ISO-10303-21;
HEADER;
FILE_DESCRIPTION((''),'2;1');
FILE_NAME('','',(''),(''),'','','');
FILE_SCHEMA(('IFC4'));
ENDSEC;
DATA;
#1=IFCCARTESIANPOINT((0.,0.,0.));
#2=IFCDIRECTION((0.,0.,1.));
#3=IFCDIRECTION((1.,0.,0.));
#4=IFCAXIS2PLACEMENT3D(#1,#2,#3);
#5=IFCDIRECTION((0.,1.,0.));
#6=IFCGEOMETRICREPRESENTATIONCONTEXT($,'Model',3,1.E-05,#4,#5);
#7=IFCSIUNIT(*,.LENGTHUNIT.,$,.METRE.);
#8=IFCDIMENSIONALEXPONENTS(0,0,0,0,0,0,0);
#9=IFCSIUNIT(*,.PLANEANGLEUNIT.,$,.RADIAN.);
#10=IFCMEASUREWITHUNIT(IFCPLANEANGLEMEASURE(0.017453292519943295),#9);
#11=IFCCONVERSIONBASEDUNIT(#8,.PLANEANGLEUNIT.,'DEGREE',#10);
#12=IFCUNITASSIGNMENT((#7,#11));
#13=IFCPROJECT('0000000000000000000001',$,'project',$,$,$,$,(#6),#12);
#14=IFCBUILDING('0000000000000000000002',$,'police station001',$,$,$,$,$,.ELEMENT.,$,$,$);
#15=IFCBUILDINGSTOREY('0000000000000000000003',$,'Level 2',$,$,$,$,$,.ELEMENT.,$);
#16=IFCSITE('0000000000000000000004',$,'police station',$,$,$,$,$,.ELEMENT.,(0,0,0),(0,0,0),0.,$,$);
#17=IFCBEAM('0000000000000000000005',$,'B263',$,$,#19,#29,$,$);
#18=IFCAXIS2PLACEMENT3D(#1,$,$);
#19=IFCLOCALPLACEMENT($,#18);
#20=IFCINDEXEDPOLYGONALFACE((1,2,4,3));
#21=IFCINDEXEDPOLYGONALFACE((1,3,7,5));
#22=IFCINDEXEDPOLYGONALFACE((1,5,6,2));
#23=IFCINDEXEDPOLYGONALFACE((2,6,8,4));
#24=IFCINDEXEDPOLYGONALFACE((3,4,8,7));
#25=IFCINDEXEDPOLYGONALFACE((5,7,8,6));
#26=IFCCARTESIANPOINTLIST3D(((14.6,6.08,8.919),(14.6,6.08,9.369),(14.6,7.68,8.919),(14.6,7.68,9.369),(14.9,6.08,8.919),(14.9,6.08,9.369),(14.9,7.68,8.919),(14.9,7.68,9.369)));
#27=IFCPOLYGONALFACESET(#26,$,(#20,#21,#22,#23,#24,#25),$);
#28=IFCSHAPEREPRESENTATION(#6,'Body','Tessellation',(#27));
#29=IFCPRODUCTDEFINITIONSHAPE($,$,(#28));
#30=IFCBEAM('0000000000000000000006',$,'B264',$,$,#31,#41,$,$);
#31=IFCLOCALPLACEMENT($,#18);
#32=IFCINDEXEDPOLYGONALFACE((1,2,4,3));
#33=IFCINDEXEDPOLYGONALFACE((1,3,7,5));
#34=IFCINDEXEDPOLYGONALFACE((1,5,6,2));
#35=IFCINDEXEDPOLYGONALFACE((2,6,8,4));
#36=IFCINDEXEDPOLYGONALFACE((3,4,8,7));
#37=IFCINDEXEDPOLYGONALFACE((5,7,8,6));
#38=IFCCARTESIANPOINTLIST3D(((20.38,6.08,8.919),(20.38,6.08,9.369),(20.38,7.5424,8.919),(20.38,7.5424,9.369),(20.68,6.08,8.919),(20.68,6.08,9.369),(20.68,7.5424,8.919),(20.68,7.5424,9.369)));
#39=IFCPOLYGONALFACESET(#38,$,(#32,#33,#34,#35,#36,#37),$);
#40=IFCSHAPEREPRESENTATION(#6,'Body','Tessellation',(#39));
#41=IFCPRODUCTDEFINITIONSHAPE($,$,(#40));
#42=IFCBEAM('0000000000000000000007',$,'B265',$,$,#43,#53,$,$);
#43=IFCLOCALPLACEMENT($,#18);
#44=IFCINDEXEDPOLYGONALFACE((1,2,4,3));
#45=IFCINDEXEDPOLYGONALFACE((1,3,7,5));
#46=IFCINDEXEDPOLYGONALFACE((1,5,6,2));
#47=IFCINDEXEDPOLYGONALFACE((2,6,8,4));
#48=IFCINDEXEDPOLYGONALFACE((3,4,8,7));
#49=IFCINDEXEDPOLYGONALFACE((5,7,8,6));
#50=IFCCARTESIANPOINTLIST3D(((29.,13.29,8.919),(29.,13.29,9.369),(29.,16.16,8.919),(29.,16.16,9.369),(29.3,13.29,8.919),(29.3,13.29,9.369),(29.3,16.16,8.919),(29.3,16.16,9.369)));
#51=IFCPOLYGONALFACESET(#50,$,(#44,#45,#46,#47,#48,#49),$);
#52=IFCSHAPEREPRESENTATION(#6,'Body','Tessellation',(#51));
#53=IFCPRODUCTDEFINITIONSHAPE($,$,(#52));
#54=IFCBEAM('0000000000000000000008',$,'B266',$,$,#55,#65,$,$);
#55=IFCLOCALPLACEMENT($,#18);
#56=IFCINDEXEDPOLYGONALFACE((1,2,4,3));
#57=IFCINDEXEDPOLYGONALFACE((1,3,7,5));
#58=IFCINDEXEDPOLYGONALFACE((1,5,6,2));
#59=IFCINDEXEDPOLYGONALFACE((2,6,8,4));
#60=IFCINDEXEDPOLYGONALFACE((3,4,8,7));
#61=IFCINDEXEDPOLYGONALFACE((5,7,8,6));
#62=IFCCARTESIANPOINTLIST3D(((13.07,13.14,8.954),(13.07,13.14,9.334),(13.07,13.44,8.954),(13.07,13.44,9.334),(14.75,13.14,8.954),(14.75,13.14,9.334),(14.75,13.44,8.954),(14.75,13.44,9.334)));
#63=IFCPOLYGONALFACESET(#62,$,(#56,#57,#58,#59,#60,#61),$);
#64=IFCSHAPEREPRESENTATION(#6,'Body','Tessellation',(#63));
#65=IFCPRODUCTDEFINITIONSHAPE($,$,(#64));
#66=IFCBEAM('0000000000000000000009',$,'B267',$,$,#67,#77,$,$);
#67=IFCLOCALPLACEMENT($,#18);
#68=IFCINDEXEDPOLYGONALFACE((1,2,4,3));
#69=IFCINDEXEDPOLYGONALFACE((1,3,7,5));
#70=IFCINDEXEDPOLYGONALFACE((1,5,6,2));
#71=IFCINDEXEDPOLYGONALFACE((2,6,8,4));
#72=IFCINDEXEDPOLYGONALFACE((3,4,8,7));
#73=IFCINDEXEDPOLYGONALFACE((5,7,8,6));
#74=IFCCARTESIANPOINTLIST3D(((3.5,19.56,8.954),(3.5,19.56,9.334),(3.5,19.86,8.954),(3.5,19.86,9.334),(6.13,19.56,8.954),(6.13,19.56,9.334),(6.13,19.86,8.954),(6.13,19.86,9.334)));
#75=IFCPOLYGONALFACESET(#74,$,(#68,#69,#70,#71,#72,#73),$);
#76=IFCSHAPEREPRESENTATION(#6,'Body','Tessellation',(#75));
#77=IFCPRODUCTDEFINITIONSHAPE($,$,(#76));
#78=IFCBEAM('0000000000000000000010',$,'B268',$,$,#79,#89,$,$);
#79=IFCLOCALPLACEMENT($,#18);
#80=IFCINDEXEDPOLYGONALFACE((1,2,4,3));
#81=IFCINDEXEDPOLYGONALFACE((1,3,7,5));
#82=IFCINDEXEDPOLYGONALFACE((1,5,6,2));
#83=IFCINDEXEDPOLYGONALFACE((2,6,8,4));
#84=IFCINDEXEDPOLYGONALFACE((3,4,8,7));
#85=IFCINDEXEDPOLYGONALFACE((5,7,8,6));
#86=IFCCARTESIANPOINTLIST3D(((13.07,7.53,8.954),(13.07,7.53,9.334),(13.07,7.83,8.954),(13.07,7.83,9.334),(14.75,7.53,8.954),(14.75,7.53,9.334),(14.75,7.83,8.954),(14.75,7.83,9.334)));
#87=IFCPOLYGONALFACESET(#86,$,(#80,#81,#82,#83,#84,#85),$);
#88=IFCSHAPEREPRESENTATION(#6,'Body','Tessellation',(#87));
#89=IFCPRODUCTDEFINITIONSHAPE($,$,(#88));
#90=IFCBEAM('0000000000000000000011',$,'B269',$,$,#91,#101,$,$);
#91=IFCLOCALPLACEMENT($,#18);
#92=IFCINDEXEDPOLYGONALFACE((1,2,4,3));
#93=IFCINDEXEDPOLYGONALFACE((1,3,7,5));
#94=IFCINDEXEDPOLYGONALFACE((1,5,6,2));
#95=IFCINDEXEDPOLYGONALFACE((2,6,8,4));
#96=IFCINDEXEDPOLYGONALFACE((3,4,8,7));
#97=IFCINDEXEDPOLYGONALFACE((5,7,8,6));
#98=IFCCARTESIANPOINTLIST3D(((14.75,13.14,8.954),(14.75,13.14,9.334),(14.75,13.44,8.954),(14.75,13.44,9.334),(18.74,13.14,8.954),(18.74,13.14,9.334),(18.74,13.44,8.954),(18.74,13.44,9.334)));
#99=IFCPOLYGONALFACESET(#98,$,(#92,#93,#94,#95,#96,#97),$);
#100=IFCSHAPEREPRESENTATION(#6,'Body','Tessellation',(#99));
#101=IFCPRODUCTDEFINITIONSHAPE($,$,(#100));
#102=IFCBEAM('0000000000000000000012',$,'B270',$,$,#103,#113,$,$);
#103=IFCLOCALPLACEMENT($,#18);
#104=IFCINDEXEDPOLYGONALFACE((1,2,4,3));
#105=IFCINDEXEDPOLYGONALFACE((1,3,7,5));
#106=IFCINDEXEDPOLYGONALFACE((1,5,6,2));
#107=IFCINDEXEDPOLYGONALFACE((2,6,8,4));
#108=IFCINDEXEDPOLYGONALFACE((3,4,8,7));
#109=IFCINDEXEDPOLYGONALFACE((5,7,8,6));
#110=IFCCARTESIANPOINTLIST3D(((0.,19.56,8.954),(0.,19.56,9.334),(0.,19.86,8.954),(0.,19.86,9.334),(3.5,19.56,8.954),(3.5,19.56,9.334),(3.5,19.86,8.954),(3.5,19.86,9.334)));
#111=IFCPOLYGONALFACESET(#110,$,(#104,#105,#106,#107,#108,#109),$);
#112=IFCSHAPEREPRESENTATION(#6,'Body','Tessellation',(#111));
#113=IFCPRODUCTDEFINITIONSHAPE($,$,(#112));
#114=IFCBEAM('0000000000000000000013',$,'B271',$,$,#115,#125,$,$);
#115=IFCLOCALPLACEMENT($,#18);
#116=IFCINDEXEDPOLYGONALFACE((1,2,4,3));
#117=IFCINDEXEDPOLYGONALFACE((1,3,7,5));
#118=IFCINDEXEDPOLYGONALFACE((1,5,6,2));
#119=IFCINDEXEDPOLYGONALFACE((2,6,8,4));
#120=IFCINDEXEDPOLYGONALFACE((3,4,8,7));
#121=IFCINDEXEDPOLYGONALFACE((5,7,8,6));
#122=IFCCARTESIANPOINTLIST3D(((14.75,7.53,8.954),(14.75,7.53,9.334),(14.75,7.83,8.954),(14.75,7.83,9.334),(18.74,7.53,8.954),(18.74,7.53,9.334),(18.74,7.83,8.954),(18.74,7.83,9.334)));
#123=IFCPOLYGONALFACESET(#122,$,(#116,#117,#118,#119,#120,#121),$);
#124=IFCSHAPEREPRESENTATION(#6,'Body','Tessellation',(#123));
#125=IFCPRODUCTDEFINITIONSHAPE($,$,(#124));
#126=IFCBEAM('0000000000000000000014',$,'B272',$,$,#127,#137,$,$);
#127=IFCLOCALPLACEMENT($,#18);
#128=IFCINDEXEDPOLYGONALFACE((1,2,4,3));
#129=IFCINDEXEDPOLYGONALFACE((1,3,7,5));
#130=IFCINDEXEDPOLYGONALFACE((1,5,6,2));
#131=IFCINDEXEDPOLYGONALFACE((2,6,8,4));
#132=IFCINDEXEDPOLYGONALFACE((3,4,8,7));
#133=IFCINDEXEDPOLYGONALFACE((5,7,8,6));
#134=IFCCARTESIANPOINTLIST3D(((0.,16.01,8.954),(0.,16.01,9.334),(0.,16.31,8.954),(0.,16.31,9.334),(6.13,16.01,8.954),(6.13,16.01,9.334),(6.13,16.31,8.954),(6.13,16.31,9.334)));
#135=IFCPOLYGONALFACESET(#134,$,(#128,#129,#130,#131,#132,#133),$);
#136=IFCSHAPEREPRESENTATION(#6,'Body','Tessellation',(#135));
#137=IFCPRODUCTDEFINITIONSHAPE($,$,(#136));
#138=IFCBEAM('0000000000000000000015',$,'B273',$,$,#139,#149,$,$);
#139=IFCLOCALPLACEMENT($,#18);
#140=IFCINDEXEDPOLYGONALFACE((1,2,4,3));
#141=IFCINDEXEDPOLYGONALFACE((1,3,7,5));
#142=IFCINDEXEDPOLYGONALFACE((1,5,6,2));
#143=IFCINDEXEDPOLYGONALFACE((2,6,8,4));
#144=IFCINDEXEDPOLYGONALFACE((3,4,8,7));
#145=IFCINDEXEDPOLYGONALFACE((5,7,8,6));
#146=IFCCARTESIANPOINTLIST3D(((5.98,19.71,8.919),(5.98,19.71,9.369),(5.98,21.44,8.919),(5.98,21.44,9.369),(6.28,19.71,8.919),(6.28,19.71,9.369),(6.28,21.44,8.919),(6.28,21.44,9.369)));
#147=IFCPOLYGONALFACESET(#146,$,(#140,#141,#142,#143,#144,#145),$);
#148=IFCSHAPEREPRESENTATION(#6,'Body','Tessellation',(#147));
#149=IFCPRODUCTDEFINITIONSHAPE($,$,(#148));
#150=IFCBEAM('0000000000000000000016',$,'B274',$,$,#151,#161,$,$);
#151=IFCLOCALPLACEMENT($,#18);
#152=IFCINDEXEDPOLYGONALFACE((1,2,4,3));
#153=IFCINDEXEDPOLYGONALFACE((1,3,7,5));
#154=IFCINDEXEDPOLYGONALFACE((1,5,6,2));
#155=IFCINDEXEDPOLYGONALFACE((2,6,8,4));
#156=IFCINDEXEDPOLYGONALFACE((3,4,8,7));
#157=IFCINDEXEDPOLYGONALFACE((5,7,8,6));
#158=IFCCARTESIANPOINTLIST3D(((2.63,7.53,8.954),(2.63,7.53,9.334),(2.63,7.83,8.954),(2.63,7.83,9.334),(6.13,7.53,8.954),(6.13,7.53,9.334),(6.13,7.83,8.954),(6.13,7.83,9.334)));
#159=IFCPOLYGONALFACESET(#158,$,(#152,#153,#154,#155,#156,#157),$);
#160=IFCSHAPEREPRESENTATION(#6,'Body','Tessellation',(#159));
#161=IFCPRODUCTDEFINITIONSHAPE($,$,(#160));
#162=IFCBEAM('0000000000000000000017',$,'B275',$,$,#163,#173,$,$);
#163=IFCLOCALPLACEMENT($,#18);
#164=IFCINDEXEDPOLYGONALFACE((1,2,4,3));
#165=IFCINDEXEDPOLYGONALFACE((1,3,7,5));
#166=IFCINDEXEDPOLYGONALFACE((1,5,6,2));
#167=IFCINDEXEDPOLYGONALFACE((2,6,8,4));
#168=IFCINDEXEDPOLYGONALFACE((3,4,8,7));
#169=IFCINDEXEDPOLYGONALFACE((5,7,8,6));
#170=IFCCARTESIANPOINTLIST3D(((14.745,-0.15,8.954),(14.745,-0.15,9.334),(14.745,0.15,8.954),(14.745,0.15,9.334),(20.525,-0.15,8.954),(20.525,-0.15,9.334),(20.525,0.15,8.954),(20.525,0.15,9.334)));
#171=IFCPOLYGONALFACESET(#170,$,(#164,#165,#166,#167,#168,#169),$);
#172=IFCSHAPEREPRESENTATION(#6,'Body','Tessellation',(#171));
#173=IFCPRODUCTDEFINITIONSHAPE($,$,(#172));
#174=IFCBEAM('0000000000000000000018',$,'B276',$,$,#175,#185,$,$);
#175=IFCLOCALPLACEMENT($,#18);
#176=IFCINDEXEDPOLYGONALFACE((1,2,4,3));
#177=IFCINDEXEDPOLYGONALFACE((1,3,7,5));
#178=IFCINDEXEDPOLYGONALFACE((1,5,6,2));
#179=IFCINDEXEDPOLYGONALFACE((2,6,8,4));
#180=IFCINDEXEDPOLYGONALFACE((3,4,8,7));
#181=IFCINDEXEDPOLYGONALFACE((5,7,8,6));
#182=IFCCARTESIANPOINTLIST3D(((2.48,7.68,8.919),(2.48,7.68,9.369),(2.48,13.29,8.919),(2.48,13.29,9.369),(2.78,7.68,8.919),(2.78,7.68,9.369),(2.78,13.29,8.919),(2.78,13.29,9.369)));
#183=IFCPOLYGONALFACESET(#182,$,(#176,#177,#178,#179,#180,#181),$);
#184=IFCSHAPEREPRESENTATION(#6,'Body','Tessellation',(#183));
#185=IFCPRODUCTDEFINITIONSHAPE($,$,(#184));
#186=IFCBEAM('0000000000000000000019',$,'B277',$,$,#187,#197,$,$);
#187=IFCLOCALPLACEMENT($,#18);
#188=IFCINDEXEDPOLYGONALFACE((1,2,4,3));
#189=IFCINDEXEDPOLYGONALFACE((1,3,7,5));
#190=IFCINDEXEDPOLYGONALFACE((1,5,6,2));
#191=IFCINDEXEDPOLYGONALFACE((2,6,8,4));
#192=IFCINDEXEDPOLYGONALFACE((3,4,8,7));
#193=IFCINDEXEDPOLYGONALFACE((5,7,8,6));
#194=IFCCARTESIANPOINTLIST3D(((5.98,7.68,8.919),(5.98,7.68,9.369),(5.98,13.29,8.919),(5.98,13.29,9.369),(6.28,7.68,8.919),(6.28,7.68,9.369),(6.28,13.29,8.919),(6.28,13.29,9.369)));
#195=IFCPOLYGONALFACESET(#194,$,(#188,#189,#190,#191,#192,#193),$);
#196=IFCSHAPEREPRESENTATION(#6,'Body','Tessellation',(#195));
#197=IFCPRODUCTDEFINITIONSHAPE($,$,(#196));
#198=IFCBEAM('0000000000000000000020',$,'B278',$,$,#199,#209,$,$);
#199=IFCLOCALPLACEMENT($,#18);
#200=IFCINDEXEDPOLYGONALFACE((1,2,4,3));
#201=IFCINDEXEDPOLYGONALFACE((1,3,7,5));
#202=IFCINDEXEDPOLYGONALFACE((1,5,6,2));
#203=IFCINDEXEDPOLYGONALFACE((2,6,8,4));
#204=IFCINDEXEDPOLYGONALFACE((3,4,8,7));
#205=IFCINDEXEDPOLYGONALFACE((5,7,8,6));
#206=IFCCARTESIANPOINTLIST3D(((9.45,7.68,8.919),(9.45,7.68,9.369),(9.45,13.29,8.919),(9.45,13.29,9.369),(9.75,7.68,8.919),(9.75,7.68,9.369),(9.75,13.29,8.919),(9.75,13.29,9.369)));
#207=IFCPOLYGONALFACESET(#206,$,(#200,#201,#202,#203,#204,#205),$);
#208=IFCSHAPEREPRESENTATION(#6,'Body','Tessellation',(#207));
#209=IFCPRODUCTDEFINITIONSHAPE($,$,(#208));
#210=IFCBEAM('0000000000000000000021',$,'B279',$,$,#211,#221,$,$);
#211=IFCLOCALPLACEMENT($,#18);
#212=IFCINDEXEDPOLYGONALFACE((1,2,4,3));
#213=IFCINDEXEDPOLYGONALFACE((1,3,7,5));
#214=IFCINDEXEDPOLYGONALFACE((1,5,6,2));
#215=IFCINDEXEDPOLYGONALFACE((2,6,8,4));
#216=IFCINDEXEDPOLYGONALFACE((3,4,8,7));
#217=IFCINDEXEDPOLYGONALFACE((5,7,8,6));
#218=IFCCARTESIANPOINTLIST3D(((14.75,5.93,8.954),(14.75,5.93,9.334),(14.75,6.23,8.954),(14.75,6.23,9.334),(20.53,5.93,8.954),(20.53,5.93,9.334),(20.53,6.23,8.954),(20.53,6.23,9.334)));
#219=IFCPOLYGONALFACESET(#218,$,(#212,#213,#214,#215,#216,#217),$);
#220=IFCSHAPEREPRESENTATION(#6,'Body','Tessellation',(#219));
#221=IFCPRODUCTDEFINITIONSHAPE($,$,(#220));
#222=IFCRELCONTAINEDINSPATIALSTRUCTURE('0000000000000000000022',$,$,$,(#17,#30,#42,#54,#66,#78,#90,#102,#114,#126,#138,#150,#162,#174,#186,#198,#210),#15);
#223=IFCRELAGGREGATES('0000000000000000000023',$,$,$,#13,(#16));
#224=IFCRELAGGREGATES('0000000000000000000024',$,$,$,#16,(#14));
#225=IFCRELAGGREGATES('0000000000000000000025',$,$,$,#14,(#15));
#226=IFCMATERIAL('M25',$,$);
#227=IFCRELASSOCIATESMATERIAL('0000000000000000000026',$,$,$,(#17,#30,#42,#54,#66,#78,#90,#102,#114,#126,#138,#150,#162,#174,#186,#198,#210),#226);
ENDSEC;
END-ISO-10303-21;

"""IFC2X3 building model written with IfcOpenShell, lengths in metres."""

from ifc_helpers import new_model, entity, si_unit, converted_unit, direction, frame, frame_2d, origin_with_axes, place, context, project, spatial, rectangle, extrude, material, element, save


model = new_model("IFC2X3")

# Units and contexts
model_context = context("Model", 3, precision=1e-05, world=origin_with_axes(), true_north=direction((0.0, 1.0, 0.0)))
ifc_project = project(units=[si_unit("LENGTHUNIT", "METRE"), converted_unit("PLANEANGLEUNIT", "DEGREE", entity("IfcPlaneAngleMeasure", 0.017453292519943295), si_unit("PLANEANGLEUNIT", "RADIAN"), dimensions=[0, 0, 0, 0, 0, 0, 0])], contexts=[model_context])

# Site, building, storey
site = spatial("IfcSite", under=ifc_project, Name="police station", CompositionType="ELEMENT", RefLatitude=(0, 0, 0), RefLongitude=(0, 0, 0), RefElevation=0.0)
building = spatial("IfcBuilding", under=site, Name="police station001", CompositionType="ELEMENT")
storey = spatial("IfcBuildingStorey", under=building, Name="Level 2", CompositionType="ELEMENT")

# Beams
ifc_material = material(Name="M25")
placement = place(None, origin_with_axes())
element("IfcBeam", 1, at=placement, inside=storey, material=ifc_material, Name="B263", context=model_context, shape_type="SweptSolid", body=[
    extrude(rectangle(XDim=0.3, YDim=0.45, at=frame_2d((0.0, 0.0), x_axis=(0.0, 1.0, 0.0))), frame((14.75, 6.08, 9.144), z_axis=(0.0, 1.0, 0.0), x_axis=(0.0, 0.0, -1.0)), (0.0, 0.0, 1.0), 1.6),
])
element("IfcBeam", 2, at=placement, inside=storey, material=ifc_material, Name="B264", context=model_context, shape_type="SweptSolid", body=[
    extrude(rectangle(XDim=0.3, YDim=0.45, at=frame_2d((0.0, 0.0), x_axis=(0.0, 1.0, 0.0))), frame((20.53, 6.08, 9.144), z_axis=(0.0, 1.0, 0.0), x_axis=(0.0, 0.0, -1.0)), (0.0, 0.0, 1.0), 1.4624),
])
element("IfcBeam", 3, at=placement, inside=storey, material=ifc_material, Name="B265", context=model_context, shape_type="SweptSolid", body=[
    extrude(rectangle(XDim=0.3, YDim=0.45, at=frame_2d((0.0, 0.0), x_axis=(0.0, 1.0, 0.0))), frame((29.15, 13.29, 9.144), z_axis=(0.0, 1.0, 0.0), x_axis=(0.0, 0.0, -1.0)), (0.0, 0.0, 1.0), 2.87),
])
element("IfcBeam", 4, at=placement, inside=storey, material=ifc_material, Name="B266", context=model_context, shape_type="SweptSolid", body=[
    extrude(rectangle(XDim=0.3, YDim=0.38, at=frame_2d((0.0, 0.0), x_axis=(0.0, 1.0, 0.0))), frame((13.07, 13.29, 9.144), z_axis=(1.0, 0.0, 0.0), x_axis=(0.0, 0.0, -1.0)), (0.0, 0.0, 1.0), 1.68),
])
element("IfcBeam", 5, at=placement, inside=storey, material=ifc_material, Name="B267", context=model_context, shape_type="SweptSolid", body=[
    extrude(rectangle(XDim=0.3, YDim=0.38, at=frame_2d((0.0, 0.0), x_axis=(0.0, 1.0, 0.0))), frame((3.5, 19.71, 9.144), z_axis=(1.0, 0.0, 0.0), x_axis=(0.0, 0.0, -1.0)), (0.0, 0.0, 1.0), 2.63),
])
element("IfcBeam", 6, at=placement, inside=storey, material=ifc_material, Name="B268", context=model_context, shape_type="SweptSolid", body=[
    extrude(rectangle(XDim=0.3, YDim=0.38, at=frame_2d((0.0, 0.0), x_axis=(0.0, 1.0, 0.0))), frame((13.07, 7.68, 9.144), z_axis=(1.0, 0.0, 0.0), x_axis=(0.0, 0.0, -1.0)), (0.0, 0.0, 1.0), 1.68),
])
element("IfcBeam", 7, at=placement, inside=storey, material=ifc_material, Name="B269", context=model_context, shape_type="SweptSolid", body=[
    extrude(rectangle(XDim=0.3, YDim=0.38, at=frame_2d((0.0, 0.0), x_axis=(0.0, 1.0, 0.0))), frame((14.75, 13.29, 9.144), z_axis=(1.0, 0.0, 0.0), x_axis=(0.0, 0.0, -1.0)), (0.0, 0.0, 1.0), 3.99),
])
element("IfcBeam", 8, at=placement, inside=storey, material=ifc_material, Name="B270", context=model_context, shape_type="SweptSolid", body=[
    extrude(rectangle(XDim=0.3, YDim=0.38, at=frame_2d((0.0, 0.0), x_axis=(0.0, 1.0, 0.0))), frame((0.0, 19.71, 9.144), z_axis=(1.0, 0.0, 0.0), x_axis=(0.0, 0.0, -1.0)), (0.0, 0.0, 1.0), 3.5),
])
element("IfcBeam", 9, at=placement, inside=storey, material=ifc_material, Name="B271", context=model_context, shape_type="SweptSolid", body=[
    extrude(rectangle(XDim=0.3, YDim=0.38, at=frame_2d((0.0, 0.0), x_axis=(0.0, 1.0, 0.0))), frame((14.75, 7.68, 9.144), z_axis=(1.0, 0.0, 0.0), x_axis=(0.0, 0.0, -1.0)), (0.0, 0.0, 1.0), 3.99),
])
element("IfcBeam", 10, at=placement, inside=storey, material=ifc_material, Name="B272", context=model_context, shape_type="SweptSolid", body=[
    extrude(rectangle(XDim=0.3, YDim=0.38, at=frame_2d((0.0, 0.0), x_axis=(0.0, 1.0, 0.0))), frame((6.13, 16.16, 9.144), z_axis=(-1.0, 0.0, 0.0), x_axis=(0.0, 0.0, -1.0)), (0.0, 0.0, 1.0), 6.13),
])
element("IfcBeam", 11, at=placement, inside=storey, material=ifc_material, Name="B273", context=model_context, shape_type="SweptSolid", body=[
    extrude(rectangle(XDim=0.3, YDim=0.45, at=frame_2d((0.0, 0.0), x_axis=(0.0, 1.0, 0.0))), frame((6.13, 19.71, 9.144), z_axis=(0.0, 1.0, 0.0), x_axis=(0.0, 0.0, -1.0)), (0.0, 0.0, 1.0), 1.73),
])
element("IfcBeam", 12, at=placement, inside=storey, material=ifc_material, Name="B274", context=model_context, shape_type="SweptSolid", body=[
    extrude(rectangle(XDim=0.3, YDim=0.38, at=frame_2d((0.0, 0.0), x_axis=(0.0, 1.0, 0.0))), frame((2.63, 7.68, 9.144), z_axis=(1.0, 0.0, 0.0), x_axis=(0.0, 0.0, -1.0)), (0.0, 0.0, 1.0), 3.5),
])
element("IfcBeam", 13, at=placement, inside=storey, material=ifc_material, Name="B275", context=model_context, shape_type="SweptSolid", body=[
    extrude(rectangle(XDim=0.3, YDim=0.38, at=frame_2d((0.0, 0.0), x_axis=(0.0, 1.0, 0.0))), frame((14.745, 0.0, 9.144), z_axis=(1.0, 0.0, 0.0), x_axis=(0.0, 0.0, -1.0)), (0.0, 0.0, 1.0), 5.78),
])
element("IfcBeam", 14, at=placement, inside=storey, material=ifc_material, Name="B276", context=model_context, shape_type="SweptSolid", body=[
    extrude(rectangle(XDim=0.3, YDim=0.45, at=frame_2d((0.0, 0.0), x_axis=(0.0, 1.0, 0.0))), frame((2.63, 13.29, 9.144), z_axis=(0.0, -1.0, 0.0), x_axis=(0.0, 0.0, -1.0)), (0.0, 0.0, 1.0), 5.61),
])
element("IfcBeam", 15, at=placement, inside=storey, material=ifc_material, Name="B277", context=model_context, shape_type="SweptSolid", body=[
    extrude(rectangle(XDim=0.3, YDim=0.45, at=frame_2d((0.0, 0.0), x_axis=(0.0, 1.0, 0.0))), frame((6.13, 7.68, 9.144), z_axis=(0.0, 1.0, 0.0), x_axis=(0.0, 0.0, -1.0)), (0.0, 0.0, 1.0), 5.61),
])
element("IfcBeam", 16, at=placement, inside=storey, material=ifc_material, Name="B278", context=model_context, shape_type="SweptSolid", body=[
    extrude(rectangle(XDim=0.3, YDim=0.45, at=frame_2d((0.0, 0.0), x_axis=(0.0, 1.0, 0.0))), frame((9.6, 7.68, 9.144), z_axis=(0.0, 1.0, 0.0), x_axis=(0.0, 0.0, -1.0)), (0.0, 0.0, 1.0), 5.61),
])
element("IfcBeam", 17, at=placement, inside=storey, material=ifc_material, Name="B279", context=model_context, shape_type="SweptSolid", body=[
    extrude(rectangle(XDim=0.3, YDim=0.38, at=frame_2d((0.0, 0.0), x_axis=(0.0, 1.0, 0.0))), frame((20.53, 6.08, 9.144), z_axis=(-1.0, 0.0, 0.0), x_axis=(0.0, 0.0, -1.0)), (0.0, 0.0, 1.0), 5.78),
])

save(model, "model.ifc")
